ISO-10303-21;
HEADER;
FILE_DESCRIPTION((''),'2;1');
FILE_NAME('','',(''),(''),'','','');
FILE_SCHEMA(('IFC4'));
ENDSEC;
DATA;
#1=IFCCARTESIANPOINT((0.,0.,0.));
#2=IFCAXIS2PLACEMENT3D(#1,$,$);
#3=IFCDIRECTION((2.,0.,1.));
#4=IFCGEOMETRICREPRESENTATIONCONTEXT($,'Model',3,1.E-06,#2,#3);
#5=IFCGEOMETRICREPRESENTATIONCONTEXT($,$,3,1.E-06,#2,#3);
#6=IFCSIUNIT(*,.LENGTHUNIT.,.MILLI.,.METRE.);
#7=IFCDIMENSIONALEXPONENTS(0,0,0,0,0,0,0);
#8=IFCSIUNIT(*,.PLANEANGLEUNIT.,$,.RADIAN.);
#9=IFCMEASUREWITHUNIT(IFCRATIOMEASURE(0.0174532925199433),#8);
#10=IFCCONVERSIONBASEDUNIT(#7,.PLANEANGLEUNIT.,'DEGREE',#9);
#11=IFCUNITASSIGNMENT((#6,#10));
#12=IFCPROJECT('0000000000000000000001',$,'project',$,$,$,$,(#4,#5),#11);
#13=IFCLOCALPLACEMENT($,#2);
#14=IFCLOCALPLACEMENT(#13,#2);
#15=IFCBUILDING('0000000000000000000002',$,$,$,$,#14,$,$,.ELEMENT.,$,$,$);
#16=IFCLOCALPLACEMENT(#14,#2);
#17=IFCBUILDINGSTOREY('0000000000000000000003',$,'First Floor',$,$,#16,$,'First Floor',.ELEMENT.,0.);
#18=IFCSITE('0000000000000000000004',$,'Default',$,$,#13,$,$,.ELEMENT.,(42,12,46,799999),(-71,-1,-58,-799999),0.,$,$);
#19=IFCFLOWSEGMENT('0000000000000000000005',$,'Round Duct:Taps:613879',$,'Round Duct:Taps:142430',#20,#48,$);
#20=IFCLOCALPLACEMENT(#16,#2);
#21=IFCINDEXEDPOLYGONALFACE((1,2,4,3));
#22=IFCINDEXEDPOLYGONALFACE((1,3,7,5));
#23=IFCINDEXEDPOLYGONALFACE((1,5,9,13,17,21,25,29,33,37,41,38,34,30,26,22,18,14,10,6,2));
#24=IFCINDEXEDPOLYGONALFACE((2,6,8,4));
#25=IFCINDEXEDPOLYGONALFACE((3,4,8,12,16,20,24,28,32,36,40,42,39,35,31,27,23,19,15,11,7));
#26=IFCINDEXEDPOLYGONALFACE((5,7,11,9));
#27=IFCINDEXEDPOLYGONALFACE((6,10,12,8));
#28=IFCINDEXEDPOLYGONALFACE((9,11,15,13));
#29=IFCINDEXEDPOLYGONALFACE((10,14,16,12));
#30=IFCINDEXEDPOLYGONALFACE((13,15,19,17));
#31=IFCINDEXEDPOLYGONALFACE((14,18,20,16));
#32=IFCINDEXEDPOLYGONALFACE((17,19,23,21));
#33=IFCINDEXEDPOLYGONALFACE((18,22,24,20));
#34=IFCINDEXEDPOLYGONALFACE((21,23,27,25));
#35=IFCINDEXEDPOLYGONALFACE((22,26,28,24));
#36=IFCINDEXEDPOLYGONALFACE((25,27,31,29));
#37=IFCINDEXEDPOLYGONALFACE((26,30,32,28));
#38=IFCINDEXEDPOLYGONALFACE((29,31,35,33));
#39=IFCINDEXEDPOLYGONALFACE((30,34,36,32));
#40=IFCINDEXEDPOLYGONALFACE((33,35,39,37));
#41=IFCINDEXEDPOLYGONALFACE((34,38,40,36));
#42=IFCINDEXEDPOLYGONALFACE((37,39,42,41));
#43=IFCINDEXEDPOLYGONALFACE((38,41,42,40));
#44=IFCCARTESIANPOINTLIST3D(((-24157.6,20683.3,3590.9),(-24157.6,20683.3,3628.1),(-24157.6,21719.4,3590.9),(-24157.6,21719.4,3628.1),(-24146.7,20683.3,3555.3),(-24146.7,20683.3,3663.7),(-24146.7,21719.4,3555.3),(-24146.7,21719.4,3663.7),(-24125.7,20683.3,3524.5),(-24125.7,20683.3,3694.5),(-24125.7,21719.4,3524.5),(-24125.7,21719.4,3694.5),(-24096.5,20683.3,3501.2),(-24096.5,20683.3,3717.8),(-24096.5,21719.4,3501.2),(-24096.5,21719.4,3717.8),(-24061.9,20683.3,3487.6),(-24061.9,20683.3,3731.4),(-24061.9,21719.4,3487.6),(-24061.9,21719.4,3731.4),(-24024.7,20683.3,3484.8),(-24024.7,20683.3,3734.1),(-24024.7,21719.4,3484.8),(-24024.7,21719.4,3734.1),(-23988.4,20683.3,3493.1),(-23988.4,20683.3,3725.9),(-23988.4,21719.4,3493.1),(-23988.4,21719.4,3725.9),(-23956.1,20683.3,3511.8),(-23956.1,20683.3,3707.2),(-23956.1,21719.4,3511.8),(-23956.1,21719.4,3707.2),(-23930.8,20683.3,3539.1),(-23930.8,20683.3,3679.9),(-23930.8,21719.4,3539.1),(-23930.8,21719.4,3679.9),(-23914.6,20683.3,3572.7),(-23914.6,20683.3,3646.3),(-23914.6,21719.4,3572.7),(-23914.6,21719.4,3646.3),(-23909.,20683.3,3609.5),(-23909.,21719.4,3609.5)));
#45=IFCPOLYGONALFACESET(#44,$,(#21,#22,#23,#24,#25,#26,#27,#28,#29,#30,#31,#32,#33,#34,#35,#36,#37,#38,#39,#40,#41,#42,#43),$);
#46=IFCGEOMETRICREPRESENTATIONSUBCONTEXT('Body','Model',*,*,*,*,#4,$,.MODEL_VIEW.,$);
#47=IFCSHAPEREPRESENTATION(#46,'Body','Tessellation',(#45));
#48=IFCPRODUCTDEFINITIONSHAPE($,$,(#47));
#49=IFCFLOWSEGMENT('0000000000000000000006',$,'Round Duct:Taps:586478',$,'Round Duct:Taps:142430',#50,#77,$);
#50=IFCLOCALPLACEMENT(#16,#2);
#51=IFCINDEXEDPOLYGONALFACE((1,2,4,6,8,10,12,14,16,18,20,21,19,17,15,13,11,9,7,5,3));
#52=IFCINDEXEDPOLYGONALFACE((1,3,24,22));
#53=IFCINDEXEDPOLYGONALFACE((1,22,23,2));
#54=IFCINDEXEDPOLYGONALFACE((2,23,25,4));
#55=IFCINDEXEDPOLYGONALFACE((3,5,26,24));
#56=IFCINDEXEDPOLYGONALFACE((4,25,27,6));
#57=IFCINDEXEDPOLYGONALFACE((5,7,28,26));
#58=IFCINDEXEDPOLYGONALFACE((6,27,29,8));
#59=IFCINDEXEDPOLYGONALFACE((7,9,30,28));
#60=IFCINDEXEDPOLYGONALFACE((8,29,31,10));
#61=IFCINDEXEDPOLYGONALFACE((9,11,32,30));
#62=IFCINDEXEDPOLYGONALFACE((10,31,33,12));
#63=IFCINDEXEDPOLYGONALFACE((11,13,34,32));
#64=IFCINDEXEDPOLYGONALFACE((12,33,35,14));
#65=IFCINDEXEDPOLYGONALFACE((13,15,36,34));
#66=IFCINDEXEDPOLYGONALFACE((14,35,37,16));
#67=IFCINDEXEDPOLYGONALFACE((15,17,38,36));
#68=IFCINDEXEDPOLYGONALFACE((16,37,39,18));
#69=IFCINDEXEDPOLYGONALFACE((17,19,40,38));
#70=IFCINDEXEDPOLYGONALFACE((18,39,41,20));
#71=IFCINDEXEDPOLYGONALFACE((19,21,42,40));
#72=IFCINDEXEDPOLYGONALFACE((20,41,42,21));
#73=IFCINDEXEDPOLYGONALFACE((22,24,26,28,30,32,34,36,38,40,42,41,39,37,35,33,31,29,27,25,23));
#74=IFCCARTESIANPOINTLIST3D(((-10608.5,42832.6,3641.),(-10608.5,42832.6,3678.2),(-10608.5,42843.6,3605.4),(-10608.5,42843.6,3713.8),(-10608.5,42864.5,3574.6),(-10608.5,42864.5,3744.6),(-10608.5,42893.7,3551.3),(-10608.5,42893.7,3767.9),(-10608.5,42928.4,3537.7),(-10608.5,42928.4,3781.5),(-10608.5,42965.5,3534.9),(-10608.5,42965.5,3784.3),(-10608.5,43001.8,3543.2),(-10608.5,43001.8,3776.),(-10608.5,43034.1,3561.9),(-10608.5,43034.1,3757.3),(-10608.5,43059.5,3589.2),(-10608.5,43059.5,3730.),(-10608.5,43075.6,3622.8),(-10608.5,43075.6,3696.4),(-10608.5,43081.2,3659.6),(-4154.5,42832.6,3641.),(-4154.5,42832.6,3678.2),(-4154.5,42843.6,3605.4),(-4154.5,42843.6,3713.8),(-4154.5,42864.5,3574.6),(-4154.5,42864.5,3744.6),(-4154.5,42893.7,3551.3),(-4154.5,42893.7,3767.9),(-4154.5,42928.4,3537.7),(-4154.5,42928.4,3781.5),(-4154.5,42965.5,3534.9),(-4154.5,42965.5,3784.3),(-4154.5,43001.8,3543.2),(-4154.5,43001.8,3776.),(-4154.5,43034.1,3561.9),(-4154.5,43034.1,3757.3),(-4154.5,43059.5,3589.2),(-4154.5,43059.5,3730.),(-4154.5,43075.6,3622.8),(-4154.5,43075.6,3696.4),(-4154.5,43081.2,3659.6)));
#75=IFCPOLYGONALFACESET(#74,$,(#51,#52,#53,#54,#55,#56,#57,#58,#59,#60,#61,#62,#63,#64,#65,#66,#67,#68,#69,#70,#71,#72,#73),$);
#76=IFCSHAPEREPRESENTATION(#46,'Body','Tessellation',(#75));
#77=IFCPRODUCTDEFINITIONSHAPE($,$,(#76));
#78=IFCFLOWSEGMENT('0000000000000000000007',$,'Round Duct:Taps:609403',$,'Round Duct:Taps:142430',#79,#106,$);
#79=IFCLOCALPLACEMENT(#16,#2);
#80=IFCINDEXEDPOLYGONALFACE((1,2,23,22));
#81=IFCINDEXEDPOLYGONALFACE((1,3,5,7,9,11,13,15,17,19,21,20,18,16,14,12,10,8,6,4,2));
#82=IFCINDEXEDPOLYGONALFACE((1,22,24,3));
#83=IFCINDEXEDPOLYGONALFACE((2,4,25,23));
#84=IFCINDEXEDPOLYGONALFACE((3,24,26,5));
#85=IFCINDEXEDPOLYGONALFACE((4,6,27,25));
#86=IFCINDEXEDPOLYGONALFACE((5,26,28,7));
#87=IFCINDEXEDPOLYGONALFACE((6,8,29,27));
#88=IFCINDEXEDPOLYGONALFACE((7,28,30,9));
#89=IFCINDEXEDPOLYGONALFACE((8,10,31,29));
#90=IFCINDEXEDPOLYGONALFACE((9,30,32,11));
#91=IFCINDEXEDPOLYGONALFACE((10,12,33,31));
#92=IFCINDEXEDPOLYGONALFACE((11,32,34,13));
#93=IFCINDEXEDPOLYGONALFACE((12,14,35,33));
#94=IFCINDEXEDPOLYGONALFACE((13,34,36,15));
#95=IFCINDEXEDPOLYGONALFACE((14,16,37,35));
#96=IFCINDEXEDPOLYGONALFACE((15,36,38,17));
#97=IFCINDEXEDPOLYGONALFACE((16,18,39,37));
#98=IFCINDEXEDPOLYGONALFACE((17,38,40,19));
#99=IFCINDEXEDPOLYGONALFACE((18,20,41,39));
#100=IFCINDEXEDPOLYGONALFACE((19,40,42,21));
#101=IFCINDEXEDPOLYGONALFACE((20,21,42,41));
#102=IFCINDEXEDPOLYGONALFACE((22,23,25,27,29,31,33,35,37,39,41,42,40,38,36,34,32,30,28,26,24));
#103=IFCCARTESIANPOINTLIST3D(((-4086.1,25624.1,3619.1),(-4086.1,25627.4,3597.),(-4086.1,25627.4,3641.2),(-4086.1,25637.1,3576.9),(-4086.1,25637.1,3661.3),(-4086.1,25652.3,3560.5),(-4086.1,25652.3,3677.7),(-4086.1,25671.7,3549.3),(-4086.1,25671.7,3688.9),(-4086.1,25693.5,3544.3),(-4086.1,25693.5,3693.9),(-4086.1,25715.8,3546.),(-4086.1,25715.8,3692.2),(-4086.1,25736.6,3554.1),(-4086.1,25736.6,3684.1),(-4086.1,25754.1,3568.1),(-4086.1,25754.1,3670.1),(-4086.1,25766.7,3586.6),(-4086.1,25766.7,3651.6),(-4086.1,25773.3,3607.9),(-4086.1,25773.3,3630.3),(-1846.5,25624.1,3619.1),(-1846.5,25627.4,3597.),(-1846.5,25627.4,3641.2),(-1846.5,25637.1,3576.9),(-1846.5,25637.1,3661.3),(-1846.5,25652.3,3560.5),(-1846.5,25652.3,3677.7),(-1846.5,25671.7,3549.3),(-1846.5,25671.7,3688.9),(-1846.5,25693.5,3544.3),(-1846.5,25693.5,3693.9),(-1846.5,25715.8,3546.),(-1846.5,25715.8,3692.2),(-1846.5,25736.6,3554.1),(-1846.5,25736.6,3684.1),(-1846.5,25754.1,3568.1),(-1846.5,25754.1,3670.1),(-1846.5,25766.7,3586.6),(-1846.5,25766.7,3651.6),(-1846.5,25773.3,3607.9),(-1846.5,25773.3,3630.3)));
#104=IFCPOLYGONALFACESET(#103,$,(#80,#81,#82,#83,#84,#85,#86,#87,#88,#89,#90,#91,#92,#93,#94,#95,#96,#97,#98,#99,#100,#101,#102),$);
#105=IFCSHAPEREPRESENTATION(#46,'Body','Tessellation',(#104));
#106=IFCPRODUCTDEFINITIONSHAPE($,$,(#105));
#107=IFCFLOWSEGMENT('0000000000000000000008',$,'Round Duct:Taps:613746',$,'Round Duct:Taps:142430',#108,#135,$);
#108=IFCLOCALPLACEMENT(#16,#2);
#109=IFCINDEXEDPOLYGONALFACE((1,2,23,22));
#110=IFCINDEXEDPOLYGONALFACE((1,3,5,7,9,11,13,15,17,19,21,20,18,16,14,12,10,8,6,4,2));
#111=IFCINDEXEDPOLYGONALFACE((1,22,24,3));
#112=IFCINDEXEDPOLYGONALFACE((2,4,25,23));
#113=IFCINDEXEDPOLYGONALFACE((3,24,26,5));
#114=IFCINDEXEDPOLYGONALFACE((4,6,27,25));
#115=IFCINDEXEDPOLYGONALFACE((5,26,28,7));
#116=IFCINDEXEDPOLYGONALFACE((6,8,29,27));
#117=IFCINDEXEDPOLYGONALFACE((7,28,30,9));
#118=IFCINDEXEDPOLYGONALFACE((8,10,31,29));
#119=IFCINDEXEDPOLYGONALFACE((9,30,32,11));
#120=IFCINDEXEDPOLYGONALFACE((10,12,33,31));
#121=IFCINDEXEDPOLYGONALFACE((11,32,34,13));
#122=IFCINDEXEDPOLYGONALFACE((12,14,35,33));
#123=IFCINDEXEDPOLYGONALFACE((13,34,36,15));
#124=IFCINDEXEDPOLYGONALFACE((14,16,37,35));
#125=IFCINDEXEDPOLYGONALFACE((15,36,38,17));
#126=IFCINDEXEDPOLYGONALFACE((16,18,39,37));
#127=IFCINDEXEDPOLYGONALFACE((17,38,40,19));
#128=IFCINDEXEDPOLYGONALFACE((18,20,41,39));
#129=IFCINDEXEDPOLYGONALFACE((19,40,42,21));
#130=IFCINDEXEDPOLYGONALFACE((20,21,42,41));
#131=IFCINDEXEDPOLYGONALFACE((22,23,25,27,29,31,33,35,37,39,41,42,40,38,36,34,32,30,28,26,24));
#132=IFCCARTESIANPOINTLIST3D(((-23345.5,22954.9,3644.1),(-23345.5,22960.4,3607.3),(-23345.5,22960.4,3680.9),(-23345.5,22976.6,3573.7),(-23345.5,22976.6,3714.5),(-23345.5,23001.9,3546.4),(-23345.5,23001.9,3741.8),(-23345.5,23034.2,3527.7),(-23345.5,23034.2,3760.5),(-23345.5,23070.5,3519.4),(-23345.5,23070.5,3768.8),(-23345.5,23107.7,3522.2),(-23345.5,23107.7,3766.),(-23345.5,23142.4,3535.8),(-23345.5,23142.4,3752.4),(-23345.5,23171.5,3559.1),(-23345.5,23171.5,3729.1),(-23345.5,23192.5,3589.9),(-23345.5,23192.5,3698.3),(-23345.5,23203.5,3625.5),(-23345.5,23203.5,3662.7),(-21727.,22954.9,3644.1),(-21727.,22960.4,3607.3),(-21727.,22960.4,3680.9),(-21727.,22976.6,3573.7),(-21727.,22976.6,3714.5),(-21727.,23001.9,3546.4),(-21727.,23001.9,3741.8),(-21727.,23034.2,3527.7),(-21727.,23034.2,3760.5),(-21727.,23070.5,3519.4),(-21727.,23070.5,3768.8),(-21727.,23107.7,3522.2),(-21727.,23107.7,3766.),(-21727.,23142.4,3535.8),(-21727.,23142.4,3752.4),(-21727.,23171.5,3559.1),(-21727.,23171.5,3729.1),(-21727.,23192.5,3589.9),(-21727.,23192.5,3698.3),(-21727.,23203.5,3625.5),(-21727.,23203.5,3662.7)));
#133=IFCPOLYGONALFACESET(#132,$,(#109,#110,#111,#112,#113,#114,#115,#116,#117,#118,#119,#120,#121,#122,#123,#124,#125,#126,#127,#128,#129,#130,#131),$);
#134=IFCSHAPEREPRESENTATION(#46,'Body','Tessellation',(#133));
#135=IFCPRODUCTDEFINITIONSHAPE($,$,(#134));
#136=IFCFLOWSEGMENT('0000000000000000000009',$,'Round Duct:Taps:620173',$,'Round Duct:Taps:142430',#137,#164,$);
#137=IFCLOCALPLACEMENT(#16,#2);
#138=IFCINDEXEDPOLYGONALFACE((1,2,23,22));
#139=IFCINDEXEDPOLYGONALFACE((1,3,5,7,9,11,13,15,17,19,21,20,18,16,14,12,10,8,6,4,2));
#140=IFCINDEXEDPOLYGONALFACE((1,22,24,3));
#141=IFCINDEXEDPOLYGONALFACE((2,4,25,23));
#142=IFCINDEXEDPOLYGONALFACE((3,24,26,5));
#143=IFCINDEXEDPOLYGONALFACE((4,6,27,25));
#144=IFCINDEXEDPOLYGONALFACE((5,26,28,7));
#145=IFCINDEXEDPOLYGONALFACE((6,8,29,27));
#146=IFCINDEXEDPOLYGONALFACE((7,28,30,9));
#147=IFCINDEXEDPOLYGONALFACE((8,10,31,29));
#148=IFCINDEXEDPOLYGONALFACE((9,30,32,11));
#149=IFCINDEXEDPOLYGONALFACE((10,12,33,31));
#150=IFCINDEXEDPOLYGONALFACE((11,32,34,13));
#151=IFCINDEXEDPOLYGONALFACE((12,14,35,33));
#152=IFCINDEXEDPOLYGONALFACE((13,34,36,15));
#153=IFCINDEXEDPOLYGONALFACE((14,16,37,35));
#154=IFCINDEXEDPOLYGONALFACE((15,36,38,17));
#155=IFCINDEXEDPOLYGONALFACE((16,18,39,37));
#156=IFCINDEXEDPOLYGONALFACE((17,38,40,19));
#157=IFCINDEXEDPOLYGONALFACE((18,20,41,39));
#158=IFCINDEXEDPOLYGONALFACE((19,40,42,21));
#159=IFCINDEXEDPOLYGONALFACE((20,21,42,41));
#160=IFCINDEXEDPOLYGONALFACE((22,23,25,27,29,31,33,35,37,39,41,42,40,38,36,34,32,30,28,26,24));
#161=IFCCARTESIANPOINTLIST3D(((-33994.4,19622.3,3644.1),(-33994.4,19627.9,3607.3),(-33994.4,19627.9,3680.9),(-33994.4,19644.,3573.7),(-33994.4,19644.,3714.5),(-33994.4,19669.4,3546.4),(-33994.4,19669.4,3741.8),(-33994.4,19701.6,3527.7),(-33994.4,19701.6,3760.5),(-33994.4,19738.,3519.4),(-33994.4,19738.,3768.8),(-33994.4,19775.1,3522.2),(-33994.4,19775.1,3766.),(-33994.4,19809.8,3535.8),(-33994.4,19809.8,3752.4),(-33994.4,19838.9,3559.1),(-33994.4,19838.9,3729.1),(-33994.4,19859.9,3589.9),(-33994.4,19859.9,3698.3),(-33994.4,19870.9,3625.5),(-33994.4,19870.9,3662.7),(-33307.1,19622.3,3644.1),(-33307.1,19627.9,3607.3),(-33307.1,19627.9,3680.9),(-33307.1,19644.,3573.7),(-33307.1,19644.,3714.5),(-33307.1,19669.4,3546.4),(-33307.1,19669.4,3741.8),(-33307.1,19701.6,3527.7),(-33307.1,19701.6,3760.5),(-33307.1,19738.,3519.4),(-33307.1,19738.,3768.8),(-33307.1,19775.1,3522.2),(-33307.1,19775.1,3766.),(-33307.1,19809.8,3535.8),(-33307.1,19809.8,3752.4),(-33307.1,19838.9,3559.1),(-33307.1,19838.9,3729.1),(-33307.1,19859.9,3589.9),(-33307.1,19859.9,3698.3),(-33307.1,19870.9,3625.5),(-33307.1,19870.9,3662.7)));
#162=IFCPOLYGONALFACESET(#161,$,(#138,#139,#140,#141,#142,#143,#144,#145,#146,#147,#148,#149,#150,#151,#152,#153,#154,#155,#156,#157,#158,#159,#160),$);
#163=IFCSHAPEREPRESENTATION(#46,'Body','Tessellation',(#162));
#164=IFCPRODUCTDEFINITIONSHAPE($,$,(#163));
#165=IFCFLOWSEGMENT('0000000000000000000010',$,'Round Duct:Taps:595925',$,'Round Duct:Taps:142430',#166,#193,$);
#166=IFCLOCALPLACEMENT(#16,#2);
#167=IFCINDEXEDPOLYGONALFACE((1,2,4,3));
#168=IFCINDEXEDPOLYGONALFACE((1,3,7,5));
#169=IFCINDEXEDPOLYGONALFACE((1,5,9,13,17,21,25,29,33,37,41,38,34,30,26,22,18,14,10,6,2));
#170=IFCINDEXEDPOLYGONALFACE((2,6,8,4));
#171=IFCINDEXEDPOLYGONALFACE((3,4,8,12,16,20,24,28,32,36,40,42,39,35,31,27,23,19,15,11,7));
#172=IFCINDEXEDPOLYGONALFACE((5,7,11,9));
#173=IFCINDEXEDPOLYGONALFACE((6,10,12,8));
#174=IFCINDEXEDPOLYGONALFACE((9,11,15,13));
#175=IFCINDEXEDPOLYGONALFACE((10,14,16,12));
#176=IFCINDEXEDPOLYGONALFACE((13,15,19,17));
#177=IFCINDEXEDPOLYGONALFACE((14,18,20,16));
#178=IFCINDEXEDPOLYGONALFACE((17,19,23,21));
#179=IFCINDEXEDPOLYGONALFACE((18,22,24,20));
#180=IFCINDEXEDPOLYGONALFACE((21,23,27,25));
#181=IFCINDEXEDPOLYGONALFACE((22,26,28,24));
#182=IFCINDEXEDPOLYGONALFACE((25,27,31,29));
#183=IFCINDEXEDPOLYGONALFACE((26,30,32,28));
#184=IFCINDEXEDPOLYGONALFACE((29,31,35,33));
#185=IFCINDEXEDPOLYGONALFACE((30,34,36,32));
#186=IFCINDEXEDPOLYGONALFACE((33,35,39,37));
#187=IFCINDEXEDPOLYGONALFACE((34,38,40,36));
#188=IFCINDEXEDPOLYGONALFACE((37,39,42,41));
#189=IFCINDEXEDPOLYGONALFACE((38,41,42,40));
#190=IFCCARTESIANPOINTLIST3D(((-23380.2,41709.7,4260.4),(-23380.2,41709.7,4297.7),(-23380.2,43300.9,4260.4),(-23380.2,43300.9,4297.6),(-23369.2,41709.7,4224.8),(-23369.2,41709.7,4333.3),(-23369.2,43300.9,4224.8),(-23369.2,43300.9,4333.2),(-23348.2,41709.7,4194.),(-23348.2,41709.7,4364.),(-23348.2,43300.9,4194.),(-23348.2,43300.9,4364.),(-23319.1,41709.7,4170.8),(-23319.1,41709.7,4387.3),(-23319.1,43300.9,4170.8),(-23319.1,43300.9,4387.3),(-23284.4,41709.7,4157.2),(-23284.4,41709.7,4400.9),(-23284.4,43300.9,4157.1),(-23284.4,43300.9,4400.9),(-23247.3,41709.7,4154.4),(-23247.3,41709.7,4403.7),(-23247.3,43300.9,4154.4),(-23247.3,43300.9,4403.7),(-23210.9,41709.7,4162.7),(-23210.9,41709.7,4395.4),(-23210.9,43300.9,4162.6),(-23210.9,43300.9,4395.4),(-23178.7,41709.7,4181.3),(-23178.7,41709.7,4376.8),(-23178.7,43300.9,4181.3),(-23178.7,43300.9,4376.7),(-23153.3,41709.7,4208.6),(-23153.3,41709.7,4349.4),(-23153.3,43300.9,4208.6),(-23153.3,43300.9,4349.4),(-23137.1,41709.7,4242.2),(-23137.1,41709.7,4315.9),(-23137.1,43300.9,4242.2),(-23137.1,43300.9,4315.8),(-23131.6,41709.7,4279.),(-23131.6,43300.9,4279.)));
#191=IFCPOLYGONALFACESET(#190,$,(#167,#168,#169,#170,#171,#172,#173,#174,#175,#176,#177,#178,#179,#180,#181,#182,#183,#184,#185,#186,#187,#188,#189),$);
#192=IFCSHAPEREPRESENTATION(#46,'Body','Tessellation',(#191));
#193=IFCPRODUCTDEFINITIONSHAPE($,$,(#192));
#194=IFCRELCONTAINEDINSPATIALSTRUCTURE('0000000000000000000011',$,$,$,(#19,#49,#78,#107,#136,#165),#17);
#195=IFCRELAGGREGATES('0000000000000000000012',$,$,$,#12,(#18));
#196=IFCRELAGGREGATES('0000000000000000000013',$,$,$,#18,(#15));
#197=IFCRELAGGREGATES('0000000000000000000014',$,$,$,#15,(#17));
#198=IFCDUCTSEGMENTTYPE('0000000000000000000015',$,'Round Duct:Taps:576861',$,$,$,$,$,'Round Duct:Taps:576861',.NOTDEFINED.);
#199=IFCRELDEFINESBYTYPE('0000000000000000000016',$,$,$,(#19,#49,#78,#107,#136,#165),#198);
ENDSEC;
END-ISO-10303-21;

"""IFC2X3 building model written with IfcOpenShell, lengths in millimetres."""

from ifc_helpers import new_model, entity, si_unit, converted_unit, direction, frame, frame_2d, origin, origin_2d_with_axis, place, context, subcontext, project, spatial, circle, extrude, type_object, element, save


model = new_model("IFC2X3")

# Units and contexts
model_context = context("Model", 3, precision=1e-06, world=origin(), true_north=direction((2.0, 0.0, 1.0)))
context_of_model = context(None, 3, precision=1e-06, world=origin(), true_north=direction((2.0, 0.0, 1.0)))
body_context = subcontext(model_context, "Body", "Model", "MODEL_VIEW")
ifc_project = project(units=[si_unit("LENGTHUNIT", "METRE", prefix="MILLI"), converted_unit("PLANEANGLEUNIT", "DEGREE", entity("IfcRatioMeasure", 0.0174532925199433), si_unit("PLANEANGLEUNIT", "RADIAN"), dimensions=[0, 0, 0, 0, 0, 0, 0])], contexts=[model_context, context_of_model])

# Site, building, storey
site_placement = place(None, origin())
site = spatial("IfcSite", under=ifc_project, at=site_placement, Name="Default", CompositionType="ELEMENT", RefLatitude=(42, 12, 46, 799999), RefLongitude=(-71, -1, -58, -799999), RefElevation=0.0)
building_placement = place(site_placement, origin())
building = spatial("IfcBuilding", under=site, at=building_placement, CompositionType="ELEMENT")
storey_placement = place(building_placement, origin())
storey = spatial("IfcBuildingStorey", under=building, at=storey_placement, Name="First Floor", LongName="First Floor", CompositionType="ELEMENT", Elevation=0.0)

# Flow segments
duct_segment_type_1 = type_object("IfcDuctSegmentType", Name="Round Duct:Taps:576861", ElementType="Round Duct:Taps:576861", PredefinedType="NOTDEFINED")
flow_segment_1_placement = place(storey_placement, origin())
element("IfcFlowSegment", 1, at=flow_segment_1_placement, inside=storey, type_object=duct_segment_type_1, Name="Round Duct:Taps:613879", ObjectType="Round Duct:Taps:142430", context=body_context, shape_type="SweptSolid", body=[
    extrude(circle(Radius=125.0, at=origin_2d_with_axis()), frame((-24034.0, 20683.3, 3609.5), z_axis=(0.0, 1.0, 0.0), x_axis=(1.0, 0.0, 0.0)), (0.0, 0.0, 1.0), 1036.2),
])
flow_segment_2_placement = place(storey_placement, origin())
element("IfcFlowSegment", 2, at=flow_segment_2_placement, inside=storey, type_object=duct_segment_type_1, Name="Round Duct:Taps:586478", ObjectType="Round Duct:Taps:142430", context=body_context, shape_type="SweptSolid", body=[
    extrude(circle(Radius=125.0, at=frame_2d((0.0, 0.0), x_axis=(1.0, 0.0))), frame((-10608.5, 42956.2, 3659.6), z_axis=(1.0, 0.0, 0.0), x_axis=(0.0, 1.0, 0.0)), (0.0, 0.0, 1.0), 6454.0),
])
flow_segment_3_placement = place(storey_placement, origin())
element("IfcFlowSegment", 3, at=flow_segment_3_placement, inside=storey, type_object=duct_segment_type_1, Name="Round Duct:Taps:609403", ObjectType="Round Duct:Taps:142430", context=body_context, shape_type="SweptSolid", body=[
    extrude(circle(Radius=75.0, at=frame_2d((0.0, 0.0), x_axis=(1.0, 0.0))), frame((-4086.1, 25699.1, 3619.1), z_axis=(1.0, 0.0, 0.0), x_axis=(0.0, -1.0, 0.0)), (0.0, 0.0, 1.0), 2239.6),
])
flow_segment_4_placement = place(storey_placement, origin())
element("IfcFlowSegment", 4, at=flow_segment_4_placement, inside=storey, type_object=duct_segment_type_1, Name="Round Duct:Taps:613746", ObjectType="Round Duct:Taps:142430", context=body_context, shape_type="SweptSolid", body=[
    extrude(circle(Radius=125.0, at=origin_2d_with_axis()), frame((-23345.5, 23079.9, 3644.1), z_axis=(1.0, 0.0, 0.0), x_axis=(0.0, -1.0, 0.0)), (0.0, 0.0, 1.0), 1618.5),
])
flow_segment_5_placement = place(storey_placement, origin())
element("IfcFlowSegment", 5, at=flow_segment_5_placement, inside=storey, type_object=duct_segment_type_1, Name="Round Duct:Taps:620173", ObjectType="Round Duct:Taps:142430", context=body_context, shape_type="SweptSolid", body=[
    extrude(circle(Radius=125.0, at=frame_2d((0.0, 0.0), x_axis=(1.0, 0.0))), frame((-33994.4, 19747.3, 3644.1), z_axis=(1.0, 0.0, 0.0), x_axis=(0.0, -1.0, 0.0)), (0.0, 0.0, 1.0), 687.4),
])
flow_segment_6_placement = place(storey_placement, origin())
element("IfcFlowSegment", 6, at=flow_segment_6_placement, inside=storey, type_object=duct_segment_type_1, Name="Round Duct:Taps:595925", ObjectType="Round Duct:Taps:142430", context=body_context, shape_type="SweptSolid", body=[
    extrude(circle(Radius=125.0, at=origin_2d_with_axis()), frame((-23256.6, 41709.7, 4279.0), z_axis=(0.0, 1.0, -0.000013), x_axis=(1.0, 0.0, 0.0)), (0.0, 0.0, 1.0), 1591.1),
])

save(model, "model.ifc")
